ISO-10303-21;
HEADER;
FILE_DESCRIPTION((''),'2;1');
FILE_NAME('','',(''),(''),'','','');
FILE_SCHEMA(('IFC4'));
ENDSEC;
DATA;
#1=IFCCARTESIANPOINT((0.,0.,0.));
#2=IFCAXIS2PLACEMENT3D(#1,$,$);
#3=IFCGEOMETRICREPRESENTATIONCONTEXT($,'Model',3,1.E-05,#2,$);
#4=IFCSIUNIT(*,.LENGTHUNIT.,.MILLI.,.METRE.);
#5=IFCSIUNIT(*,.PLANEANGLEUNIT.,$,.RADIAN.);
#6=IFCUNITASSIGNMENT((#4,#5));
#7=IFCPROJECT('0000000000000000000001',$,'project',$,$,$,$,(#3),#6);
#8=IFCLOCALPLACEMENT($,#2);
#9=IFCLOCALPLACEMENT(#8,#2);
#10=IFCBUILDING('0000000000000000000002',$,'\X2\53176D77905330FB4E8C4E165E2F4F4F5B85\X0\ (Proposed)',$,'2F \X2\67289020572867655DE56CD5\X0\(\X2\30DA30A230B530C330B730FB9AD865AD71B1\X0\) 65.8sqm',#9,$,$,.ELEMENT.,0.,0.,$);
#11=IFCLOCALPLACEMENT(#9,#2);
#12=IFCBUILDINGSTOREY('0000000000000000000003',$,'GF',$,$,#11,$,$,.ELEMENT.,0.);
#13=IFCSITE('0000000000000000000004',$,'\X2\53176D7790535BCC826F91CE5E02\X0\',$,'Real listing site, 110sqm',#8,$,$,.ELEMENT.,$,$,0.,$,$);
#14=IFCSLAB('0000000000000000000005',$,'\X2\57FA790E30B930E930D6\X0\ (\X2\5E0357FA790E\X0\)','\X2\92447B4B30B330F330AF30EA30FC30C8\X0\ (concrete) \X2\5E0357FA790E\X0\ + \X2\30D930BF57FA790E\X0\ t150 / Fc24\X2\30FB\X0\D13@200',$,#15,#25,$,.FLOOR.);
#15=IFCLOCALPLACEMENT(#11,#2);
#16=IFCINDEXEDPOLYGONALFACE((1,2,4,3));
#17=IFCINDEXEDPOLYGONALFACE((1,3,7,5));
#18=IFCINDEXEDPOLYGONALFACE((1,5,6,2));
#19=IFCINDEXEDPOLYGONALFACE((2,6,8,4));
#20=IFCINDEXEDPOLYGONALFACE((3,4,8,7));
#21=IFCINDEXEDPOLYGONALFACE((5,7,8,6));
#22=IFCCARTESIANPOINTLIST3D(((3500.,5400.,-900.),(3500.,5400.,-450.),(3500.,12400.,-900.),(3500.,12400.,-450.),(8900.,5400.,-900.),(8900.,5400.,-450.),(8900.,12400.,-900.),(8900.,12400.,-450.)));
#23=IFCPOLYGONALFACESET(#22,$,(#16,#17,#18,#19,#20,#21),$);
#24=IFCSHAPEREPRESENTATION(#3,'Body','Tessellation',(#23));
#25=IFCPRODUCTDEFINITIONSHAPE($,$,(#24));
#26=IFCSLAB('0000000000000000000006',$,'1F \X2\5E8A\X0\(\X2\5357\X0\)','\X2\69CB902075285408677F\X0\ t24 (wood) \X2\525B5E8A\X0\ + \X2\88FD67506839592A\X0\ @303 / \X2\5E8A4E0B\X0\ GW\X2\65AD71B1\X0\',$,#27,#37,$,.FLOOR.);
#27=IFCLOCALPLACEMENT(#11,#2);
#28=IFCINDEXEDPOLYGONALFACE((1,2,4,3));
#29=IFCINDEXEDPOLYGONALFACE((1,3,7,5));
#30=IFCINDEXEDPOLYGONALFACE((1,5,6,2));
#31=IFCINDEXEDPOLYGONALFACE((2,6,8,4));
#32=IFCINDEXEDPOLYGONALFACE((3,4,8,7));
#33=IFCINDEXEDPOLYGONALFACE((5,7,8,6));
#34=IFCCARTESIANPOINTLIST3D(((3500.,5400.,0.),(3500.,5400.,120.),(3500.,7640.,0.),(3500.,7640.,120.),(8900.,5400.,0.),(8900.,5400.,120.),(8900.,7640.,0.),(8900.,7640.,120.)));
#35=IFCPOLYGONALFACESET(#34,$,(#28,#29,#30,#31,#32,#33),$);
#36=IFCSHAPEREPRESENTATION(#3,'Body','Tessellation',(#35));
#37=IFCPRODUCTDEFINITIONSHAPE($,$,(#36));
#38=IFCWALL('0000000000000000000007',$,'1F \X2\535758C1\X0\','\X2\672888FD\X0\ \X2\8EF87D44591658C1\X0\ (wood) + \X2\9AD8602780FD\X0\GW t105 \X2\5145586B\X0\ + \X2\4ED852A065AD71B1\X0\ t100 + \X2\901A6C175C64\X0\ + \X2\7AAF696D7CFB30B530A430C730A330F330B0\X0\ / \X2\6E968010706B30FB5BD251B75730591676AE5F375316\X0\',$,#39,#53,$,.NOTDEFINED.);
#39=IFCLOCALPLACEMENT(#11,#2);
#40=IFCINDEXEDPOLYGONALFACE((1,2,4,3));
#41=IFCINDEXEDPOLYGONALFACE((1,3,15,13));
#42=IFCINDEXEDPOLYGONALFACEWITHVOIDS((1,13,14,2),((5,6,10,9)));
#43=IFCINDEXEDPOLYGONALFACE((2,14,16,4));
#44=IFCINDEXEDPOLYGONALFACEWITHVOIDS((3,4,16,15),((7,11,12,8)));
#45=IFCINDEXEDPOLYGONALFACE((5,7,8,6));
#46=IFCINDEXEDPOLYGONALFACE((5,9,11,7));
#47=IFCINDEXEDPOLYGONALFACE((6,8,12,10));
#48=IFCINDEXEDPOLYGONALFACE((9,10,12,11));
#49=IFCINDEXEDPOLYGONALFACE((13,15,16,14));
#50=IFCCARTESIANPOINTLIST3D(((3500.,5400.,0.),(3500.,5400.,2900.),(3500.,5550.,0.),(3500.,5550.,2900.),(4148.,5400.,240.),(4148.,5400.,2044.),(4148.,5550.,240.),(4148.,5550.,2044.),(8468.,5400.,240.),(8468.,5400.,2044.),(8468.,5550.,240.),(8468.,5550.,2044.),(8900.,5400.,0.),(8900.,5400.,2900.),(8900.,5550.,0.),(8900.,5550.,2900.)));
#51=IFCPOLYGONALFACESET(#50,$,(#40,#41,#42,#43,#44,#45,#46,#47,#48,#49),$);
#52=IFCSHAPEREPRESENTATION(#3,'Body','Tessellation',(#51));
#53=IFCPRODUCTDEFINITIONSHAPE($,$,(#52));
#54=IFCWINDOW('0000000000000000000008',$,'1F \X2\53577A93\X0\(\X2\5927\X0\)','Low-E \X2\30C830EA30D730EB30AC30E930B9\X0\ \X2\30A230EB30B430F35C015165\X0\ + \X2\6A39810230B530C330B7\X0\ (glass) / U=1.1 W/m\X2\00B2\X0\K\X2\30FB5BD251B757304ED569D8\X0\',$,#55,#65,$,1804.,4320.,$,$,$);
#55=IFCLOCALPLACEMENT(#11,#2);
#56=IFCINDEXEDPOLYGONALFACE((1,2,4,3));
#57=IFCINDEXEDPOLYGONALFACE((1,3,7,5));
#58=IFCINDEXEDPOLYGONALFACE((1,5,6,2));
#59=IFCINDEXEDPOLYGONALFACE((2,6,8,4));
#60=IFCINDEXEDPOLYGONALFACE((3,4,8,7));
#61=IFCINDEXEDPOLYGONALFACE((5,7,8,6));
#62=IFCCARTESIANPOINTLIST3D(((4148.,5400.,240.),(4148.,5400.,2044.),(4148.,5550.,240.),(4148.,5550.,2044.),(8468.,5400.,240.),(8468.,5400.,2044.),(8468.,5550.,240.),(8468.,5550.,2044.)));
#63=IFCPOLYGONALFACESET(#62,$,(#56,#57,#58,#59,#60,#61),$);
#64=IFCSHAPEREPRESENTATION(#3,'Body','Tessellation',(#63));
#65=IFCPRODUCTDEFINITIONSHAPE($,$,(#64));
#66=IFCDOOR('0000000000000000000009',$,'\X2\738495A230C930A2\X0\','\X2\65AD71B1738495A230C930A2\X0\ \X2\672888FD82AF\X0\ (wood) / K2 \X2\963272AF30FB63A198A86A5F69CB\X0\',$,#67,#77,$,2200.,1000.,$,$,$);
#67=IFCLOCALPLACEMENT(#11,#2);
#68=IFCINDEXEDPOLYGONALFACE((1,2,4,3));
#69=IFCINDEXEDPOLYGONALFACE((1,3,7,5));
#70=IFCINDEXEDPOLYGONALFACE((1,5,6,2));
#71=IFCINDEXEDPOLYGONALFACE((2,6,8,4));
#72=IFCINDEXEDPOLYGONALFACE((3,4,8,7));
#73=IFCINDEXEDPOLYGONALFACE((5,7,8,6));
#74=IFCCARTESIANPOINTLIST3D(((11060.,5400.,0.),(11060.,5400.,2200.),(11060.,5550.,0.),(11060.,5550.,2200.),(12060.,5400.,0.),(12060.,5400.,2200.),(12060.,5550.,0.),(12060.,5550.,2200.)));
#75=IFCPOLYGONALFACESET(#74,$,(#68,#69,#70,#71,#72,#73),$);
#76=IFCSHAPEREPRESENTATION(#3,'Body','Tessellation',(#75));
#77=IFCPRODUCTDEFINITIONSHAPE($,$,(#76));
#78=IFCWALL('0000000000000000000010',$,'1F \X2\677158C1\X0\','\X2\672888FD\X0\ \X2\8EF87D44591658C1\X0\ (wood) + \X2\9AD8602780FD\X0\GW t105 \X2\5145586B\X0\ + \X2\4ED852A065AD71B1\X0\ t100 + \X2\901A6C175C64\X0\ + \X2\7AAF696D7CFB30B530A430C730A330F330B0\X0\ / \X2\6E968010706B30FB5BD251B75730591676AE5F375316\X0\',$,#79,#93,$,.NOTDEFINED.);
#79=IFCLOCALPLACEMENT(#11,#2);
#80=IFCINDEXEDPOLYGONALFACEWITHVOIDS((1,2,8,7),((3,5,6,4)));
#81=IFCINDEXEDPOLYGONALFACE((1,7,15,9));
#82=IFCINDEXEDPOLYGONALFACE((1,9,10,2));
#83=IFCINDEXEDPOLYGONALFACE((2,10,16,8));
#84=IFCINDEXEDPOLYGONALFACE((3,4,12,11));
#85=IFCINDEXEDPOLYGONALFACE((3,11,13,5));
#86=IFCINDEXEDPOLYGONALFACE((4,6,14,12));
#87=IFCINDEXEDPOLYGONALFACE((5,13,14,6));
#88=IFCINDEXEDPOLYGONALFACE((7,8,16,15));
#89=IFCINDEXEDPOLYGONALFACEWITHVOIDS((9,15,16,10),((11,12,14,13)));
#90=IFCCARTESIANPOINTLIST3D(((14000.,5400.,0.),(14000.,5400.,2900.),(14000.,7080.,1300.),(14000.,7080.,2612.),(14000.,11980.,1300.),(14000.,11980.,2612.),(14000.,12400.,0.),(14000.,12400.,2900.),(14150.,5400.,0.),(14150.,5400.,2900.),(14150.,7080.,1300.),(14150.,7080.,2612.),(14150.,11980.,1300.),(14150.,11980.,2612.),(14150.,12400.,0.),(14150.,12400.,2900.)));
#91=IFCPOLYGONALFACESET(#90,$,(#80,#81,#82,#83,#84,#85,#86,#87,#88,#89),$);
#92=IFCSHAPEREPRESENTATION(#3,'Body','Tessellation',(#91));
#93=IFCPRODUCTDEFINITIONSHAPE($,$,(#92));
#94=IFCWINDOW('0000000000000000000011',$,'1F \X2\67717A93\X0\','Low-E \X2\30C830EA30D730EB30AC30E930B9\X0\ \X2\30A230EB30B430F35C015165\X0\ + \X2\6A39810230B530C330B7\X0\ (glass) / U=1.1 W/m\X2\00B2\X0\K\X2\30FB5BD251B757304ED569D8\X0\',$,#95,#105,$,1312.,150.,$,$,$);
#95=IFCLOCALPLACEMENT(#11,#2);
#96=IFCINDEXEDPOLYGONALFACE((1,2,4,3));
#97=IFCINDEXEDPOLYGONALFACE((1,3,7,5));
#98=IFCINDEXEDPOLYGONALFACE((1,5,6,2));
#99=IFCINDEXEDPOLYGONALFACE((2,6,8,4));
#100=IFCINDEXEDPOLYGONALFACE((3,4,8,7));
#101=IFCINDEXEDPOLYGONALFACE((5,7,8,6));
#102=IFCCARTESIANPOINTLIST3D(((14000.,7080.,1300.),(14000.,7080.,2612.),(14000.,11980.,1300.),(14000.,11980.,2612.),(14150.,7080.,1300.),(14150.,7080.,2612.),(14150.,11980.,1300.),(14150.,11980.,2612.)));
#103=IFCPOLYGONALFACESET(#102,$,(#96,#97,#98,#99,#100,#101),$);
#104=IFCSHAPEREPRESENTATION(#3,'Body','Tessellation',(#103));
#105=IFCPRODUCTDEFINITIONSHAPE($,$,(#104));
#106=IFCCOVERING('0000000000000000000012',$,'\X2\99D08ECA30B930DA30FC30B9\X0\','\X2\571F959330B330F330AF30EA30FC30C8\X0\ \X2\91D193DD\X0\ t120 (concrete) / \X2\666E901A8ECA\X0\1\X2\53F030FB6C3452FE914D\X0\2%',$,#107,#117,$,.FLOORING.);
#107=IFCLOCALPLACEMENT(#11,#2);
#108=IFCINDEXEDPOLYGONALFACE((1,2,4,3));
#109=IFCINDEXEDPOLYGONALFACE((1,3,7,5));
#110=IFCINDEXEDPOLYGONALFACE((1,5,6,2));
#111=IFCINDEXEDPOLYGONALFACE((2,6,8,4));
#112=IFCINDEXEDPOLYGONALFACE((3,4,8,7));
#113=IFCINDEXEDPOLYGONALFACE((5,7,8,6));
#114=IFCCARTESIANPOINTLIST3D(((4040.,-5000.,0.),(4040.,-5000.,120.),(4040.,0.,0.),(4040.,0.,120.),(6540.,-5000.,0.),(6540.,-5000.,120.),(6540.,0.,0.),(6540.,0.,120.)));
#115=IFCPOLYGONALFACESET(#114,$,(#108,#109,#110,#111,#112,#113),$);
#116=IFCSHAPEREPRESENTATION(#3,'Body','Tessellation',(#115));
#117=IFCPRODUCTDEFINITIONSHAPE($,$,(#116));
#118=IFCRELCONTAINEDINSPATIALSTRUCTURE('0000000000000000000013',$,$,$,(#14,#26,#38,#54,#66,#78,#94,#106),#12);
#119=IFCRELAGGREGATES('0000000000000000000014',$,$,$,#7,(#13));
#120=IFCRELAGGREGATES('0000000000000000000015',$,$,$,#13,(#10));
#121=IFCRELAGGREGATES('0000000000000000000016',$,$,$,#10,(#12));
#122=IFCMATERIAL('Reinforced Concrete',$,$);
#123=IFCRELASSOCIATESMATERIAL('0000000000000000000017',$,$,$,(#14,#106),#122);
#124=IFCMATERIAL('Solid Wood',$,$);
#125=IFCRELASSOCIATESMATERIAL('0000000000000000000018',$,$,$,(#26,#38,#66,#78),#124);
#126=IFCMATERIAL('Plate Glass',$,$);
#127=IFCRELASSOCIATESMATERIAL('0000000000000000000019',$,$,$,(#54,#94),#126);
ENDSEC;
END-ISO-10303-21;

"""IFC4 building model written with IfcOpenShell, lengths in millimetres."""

from ifc_helpers import new_model, si_unit, frame, frame_2d, origin, place, context, project, spatial, rectangle, extrude, material, element, fill, save


model = new_model("IFC4")

# Units and contexts
model_context = context("Model", 3, precision=1e-05, world=origin())
ifc_project = project(units=[si_unit("LENGTHUNIT", "METRE", prefix="MILLI"), si_unit("PLANEANGLEUNIT", "RADIAN")], contexts=[model_context])

# Site, building, storey
site_placement = place(None, origin())
site = spatial("IfcSite", under=ifc_project, at=site_placement, Name="北海道富良野市", ObjectType="Real listing site, 110sqm", CompositionType="ELEMENT", RefElevation=0.0)
building_placement = place(site_placement, origin())
building = spatial("IfcBuilding", under=site, at=building_placement, Name="北海道・二世帯住宅 (Proposed)", ObjectType="2F 木造在来工法(ペアサッシ・高断熱) 65.8sqm", CompositionType="ELEMENT", ElevationOfRefHeight=0.0, ElevationOfTerrain=0.0)
storey_placement = place(building_placement, origin())
storey = spatial("IfcBuildingStorey", under=building, at=storey_placement, Name="GF", CompositionType="ELEMENT", Elevation=0.0)

# Shared definitions
ifc_material_1 = material(Name="Solid Wood")

# Slabs
ifc_material_2 = material(Name="Reinforced Concrete")
slab_1_placement = place(storey_placement, frame((1750.0, 2700.0, -450.0)))
element("IfcSlab", 1, at=slab_1_placement, inside=storey, material=ifc_material_2, Name="基礎スラブ (布基礎)", Description="鉄筋コンクリート (concrete) 布基礎 + ベタ基礎 t150 / Fc24・D13@200", PredefinedType="FLOOR", context=model_context, shape_type="SweptSolid", body=[
    extrude(rectangle(XDim=5400.0, YDim=7000.0, at=frame_2d((2700.0, 3500.0))), frame((1750.0, 2700.0, -450.0)), (0.0, 0.0, 1.0), 450.0),
])
slab_2_placement = place(storey_placement, frame((1750.0, 2700.0, 0.0)))
element("IfcSlab", 2, at=slab_2_placement, inside=storey, material=ifc_material_1, Name="1F 床(南)", Description="構造用合板 t24 (wood) 剛床 + 製材根太 @303 / 床下 GW断熱", PredefinedType="FLOOR", context=model_context, shape_type="SweptSolid", body=[
    extrude(rectangle(XDim=5400.0, YDim=2240.0, at=frame_2d((2700.0, 1120.0))), frame((1750.0, 2700.0, 0.0)), (0.0, 0.0, 1.0), 120.0),
])

# Wall, openings, window, door
wall_1_placement = place(storey_placement, frame((1750.0, 2700.0, 0.0)))
wall_1 = element("IfcWall", 3, at=wall_1_placement, inside=storey, material=ifc_material_1, Name="1F 南壁", Description="木製 軸組外壁 (wood) + 高性能GW t105 充填 + 付加断熱 t100 + 通気層 + 窯業系サイディング / 準耐火・寒冷地外皮強化", PredefinedType="NOTDEFINED", context=model_context, shape_type="SweptSolid", body=[
    extrude(rectangle(XDim=5400.0, YDim=150.0, at=frame_2d((2700.0, 75.0))), frame((1750.0, 2700.0, 0.0)), (0.0, 0.0, 1.0), 2900.0),
])
opening_1_placement = place(storey_placement, frame((2074.0, 2700.0, 120.0)))
opening_1 = element("IfcOpeningElement", 4, at=opening_1_placement, cuts=wall_1, PredefinedType="NOTDEFINED", context=model_context, shape_type="SweptSolid", body=[
    extrude(rectangle(XDim=4320.0, YDim=150.0, at=frame_2d((2160.0, 75.0))), frame((2074.0, 2700.0, 120.0)), (0.0, 0.0, 1.0), 1804.0),
])
opening_2_placement = place(storey_placement, frame((5530.0, 2700.0, 0.0)))
opening_2 = element("IfcOpeningElement", 5, at=opening_2_placement, cuts=wall_1, PredefinedType="NOTDEFINED", context=model_context, shape_type="SweptSolid", body=[
    extrude(rectangle(XDim=1000.0, YDim=150.0, at=frame_2d((500.0, 75.0))), frame((5530.0, 2700.0, 0.0)), (0.0, 0.0, 1.0), 2200.0),
])
ifc_material_3 = material(Name="Plate Glass")
window_1_placement = place(storey_placement, frame((2074.0, 2700.0, 120.0)))
window_1 = element("IfcWindow", 6, at=window_1_placement, inside=storey, material=ifc_material_3, Name="1F 南窓(大)", Description="Low-E トリプルガラス アルゴン封入 + 樹脂サッシ (glass) / U=1.1 W/m²K・寒冷地仕様", OverallHeight=1804.0, OverallWidth=4320.0, context=model_context, shape_type="SweptSolid", body=[
    extrude(rectangle(XDim=4320.0, YDim=150.0, at=frame_2d((2160.0, 75.0))), frame((2074.0, 2700.0, 120.0)), (0.0, 0.0, 1.0), 1804.0),
])
fill(opening_1, window_1)
door_placement = place(storey_placement, frame((5530.0, 2700.0, 0.0)))
door = element("IfcDoor", 7, at=door_placement, inside=storey, material=ifc_material_1, Name="玄関ドア", Description="断熱玄関ドア 木製芯 (wood) / K2 防犯・採風機構", OverallHeight=2200.0, OverallWidth=1000.0, context=model_context, shape_type="SweptSolid", body=[
    extrude(rectangle(XDim=1000.0, YDim=150.0, at=frame_2d((500.0, 75.0))), frame((5530.0, 2700.0, 0.0)), (0.0, 0.0, 1.0), 2200.0),
])
fill(opening_2, door)

# Wall, opening, window
wall_2_placement = place(storey_placement, frame((7000.0, 2700.0, 0.0)))
wall_2 = element("IfcWall", 8, at=wall_2_placement, inside=storey, material=ifc_material_1, Name="1F 東壁", Description="木製 軸組外壁 (wood) + 高性能GW t105 充填 + 付加断熱 t100 + 通気層 + 窯業系サイディング / 準耐火・寒冷地外皮強化", PredefinedType="NOTDEFINED", context=model_context, shape_type="SweptSolid", body=[
    extrude(rectangle(XDim=150.0, YDim=7000.0, at=frame_2d((75.0, 3500.0))), frame((7000.0, 2700.0, 0.0)), (0.0, 0.0, 1.0), 2900.0),
])
opening_3_placement = place(storey_placement, frame((7000.0, 3540.0, 650.0)))
opening_3 = element("IfcOpeningElement", 9, at=opening_3_placement, cuts=wall_2, PredefinedType="NOTDEFINED", context=model_context, shape_type="SweptSolid", body=[
    extrude(rectangle(XDim=150.0, YDim=4900.0, at=frame_2d((75.0, 2450.0))), frame((7000.0, 3540.0, 650.0)), (0.0, 0.0, 1.0), 1312.0),
])
window_2_placement = place(storey_placement, frame((7000.0, 3540.0, 650.0)))
window_2 = element("IfcWindow", 10, at=window_2_placement, inside=storey, material=ifc_material_3, Name="1F 東窓", Description="Low-E トリプルガラス アルゴン封入 + 樹脂サッシ (glass) / U=1.1 W/m²K・寒冷地仕様", OverallHeight=1312.0, OverallWidth=150.0, context=model_context, shape_type="SweptSolid", body=[
    extrude(rectangle(XDim=150.0, YDim=4900.0, at=frame_2d((75.0, 2450.0))), frame((7000.0, 3540.0, 650.0)), (0.0, 0.0, 1.0), 1312.0),
])
fill(opening_3, window_2)

# Covering
covering_1_placement = place(storey_placement, frame((2020.0, -2500.0, 0.0)))
element("IfcCovering", 11, at=covering_1_placement, inside=storey, material=ifc_material_2, Name="駐車スペース", Description="土間コンクリート 金鏝 t120 (concrete) / 普通車1台・水勾配2%", PredefinedType="FLOORING", context=model_context, shape_type="SweptSolid", body=[
    extrude(rectangle(XDim=2500.0, YDim=5000.0, at=frame_2d((1250.0, 2500.0))), frame((2020.0, -2500.0, 0.0)), (0.0, 0.0, 1.0), 120.0),
])

save(model, "model.ifc")
